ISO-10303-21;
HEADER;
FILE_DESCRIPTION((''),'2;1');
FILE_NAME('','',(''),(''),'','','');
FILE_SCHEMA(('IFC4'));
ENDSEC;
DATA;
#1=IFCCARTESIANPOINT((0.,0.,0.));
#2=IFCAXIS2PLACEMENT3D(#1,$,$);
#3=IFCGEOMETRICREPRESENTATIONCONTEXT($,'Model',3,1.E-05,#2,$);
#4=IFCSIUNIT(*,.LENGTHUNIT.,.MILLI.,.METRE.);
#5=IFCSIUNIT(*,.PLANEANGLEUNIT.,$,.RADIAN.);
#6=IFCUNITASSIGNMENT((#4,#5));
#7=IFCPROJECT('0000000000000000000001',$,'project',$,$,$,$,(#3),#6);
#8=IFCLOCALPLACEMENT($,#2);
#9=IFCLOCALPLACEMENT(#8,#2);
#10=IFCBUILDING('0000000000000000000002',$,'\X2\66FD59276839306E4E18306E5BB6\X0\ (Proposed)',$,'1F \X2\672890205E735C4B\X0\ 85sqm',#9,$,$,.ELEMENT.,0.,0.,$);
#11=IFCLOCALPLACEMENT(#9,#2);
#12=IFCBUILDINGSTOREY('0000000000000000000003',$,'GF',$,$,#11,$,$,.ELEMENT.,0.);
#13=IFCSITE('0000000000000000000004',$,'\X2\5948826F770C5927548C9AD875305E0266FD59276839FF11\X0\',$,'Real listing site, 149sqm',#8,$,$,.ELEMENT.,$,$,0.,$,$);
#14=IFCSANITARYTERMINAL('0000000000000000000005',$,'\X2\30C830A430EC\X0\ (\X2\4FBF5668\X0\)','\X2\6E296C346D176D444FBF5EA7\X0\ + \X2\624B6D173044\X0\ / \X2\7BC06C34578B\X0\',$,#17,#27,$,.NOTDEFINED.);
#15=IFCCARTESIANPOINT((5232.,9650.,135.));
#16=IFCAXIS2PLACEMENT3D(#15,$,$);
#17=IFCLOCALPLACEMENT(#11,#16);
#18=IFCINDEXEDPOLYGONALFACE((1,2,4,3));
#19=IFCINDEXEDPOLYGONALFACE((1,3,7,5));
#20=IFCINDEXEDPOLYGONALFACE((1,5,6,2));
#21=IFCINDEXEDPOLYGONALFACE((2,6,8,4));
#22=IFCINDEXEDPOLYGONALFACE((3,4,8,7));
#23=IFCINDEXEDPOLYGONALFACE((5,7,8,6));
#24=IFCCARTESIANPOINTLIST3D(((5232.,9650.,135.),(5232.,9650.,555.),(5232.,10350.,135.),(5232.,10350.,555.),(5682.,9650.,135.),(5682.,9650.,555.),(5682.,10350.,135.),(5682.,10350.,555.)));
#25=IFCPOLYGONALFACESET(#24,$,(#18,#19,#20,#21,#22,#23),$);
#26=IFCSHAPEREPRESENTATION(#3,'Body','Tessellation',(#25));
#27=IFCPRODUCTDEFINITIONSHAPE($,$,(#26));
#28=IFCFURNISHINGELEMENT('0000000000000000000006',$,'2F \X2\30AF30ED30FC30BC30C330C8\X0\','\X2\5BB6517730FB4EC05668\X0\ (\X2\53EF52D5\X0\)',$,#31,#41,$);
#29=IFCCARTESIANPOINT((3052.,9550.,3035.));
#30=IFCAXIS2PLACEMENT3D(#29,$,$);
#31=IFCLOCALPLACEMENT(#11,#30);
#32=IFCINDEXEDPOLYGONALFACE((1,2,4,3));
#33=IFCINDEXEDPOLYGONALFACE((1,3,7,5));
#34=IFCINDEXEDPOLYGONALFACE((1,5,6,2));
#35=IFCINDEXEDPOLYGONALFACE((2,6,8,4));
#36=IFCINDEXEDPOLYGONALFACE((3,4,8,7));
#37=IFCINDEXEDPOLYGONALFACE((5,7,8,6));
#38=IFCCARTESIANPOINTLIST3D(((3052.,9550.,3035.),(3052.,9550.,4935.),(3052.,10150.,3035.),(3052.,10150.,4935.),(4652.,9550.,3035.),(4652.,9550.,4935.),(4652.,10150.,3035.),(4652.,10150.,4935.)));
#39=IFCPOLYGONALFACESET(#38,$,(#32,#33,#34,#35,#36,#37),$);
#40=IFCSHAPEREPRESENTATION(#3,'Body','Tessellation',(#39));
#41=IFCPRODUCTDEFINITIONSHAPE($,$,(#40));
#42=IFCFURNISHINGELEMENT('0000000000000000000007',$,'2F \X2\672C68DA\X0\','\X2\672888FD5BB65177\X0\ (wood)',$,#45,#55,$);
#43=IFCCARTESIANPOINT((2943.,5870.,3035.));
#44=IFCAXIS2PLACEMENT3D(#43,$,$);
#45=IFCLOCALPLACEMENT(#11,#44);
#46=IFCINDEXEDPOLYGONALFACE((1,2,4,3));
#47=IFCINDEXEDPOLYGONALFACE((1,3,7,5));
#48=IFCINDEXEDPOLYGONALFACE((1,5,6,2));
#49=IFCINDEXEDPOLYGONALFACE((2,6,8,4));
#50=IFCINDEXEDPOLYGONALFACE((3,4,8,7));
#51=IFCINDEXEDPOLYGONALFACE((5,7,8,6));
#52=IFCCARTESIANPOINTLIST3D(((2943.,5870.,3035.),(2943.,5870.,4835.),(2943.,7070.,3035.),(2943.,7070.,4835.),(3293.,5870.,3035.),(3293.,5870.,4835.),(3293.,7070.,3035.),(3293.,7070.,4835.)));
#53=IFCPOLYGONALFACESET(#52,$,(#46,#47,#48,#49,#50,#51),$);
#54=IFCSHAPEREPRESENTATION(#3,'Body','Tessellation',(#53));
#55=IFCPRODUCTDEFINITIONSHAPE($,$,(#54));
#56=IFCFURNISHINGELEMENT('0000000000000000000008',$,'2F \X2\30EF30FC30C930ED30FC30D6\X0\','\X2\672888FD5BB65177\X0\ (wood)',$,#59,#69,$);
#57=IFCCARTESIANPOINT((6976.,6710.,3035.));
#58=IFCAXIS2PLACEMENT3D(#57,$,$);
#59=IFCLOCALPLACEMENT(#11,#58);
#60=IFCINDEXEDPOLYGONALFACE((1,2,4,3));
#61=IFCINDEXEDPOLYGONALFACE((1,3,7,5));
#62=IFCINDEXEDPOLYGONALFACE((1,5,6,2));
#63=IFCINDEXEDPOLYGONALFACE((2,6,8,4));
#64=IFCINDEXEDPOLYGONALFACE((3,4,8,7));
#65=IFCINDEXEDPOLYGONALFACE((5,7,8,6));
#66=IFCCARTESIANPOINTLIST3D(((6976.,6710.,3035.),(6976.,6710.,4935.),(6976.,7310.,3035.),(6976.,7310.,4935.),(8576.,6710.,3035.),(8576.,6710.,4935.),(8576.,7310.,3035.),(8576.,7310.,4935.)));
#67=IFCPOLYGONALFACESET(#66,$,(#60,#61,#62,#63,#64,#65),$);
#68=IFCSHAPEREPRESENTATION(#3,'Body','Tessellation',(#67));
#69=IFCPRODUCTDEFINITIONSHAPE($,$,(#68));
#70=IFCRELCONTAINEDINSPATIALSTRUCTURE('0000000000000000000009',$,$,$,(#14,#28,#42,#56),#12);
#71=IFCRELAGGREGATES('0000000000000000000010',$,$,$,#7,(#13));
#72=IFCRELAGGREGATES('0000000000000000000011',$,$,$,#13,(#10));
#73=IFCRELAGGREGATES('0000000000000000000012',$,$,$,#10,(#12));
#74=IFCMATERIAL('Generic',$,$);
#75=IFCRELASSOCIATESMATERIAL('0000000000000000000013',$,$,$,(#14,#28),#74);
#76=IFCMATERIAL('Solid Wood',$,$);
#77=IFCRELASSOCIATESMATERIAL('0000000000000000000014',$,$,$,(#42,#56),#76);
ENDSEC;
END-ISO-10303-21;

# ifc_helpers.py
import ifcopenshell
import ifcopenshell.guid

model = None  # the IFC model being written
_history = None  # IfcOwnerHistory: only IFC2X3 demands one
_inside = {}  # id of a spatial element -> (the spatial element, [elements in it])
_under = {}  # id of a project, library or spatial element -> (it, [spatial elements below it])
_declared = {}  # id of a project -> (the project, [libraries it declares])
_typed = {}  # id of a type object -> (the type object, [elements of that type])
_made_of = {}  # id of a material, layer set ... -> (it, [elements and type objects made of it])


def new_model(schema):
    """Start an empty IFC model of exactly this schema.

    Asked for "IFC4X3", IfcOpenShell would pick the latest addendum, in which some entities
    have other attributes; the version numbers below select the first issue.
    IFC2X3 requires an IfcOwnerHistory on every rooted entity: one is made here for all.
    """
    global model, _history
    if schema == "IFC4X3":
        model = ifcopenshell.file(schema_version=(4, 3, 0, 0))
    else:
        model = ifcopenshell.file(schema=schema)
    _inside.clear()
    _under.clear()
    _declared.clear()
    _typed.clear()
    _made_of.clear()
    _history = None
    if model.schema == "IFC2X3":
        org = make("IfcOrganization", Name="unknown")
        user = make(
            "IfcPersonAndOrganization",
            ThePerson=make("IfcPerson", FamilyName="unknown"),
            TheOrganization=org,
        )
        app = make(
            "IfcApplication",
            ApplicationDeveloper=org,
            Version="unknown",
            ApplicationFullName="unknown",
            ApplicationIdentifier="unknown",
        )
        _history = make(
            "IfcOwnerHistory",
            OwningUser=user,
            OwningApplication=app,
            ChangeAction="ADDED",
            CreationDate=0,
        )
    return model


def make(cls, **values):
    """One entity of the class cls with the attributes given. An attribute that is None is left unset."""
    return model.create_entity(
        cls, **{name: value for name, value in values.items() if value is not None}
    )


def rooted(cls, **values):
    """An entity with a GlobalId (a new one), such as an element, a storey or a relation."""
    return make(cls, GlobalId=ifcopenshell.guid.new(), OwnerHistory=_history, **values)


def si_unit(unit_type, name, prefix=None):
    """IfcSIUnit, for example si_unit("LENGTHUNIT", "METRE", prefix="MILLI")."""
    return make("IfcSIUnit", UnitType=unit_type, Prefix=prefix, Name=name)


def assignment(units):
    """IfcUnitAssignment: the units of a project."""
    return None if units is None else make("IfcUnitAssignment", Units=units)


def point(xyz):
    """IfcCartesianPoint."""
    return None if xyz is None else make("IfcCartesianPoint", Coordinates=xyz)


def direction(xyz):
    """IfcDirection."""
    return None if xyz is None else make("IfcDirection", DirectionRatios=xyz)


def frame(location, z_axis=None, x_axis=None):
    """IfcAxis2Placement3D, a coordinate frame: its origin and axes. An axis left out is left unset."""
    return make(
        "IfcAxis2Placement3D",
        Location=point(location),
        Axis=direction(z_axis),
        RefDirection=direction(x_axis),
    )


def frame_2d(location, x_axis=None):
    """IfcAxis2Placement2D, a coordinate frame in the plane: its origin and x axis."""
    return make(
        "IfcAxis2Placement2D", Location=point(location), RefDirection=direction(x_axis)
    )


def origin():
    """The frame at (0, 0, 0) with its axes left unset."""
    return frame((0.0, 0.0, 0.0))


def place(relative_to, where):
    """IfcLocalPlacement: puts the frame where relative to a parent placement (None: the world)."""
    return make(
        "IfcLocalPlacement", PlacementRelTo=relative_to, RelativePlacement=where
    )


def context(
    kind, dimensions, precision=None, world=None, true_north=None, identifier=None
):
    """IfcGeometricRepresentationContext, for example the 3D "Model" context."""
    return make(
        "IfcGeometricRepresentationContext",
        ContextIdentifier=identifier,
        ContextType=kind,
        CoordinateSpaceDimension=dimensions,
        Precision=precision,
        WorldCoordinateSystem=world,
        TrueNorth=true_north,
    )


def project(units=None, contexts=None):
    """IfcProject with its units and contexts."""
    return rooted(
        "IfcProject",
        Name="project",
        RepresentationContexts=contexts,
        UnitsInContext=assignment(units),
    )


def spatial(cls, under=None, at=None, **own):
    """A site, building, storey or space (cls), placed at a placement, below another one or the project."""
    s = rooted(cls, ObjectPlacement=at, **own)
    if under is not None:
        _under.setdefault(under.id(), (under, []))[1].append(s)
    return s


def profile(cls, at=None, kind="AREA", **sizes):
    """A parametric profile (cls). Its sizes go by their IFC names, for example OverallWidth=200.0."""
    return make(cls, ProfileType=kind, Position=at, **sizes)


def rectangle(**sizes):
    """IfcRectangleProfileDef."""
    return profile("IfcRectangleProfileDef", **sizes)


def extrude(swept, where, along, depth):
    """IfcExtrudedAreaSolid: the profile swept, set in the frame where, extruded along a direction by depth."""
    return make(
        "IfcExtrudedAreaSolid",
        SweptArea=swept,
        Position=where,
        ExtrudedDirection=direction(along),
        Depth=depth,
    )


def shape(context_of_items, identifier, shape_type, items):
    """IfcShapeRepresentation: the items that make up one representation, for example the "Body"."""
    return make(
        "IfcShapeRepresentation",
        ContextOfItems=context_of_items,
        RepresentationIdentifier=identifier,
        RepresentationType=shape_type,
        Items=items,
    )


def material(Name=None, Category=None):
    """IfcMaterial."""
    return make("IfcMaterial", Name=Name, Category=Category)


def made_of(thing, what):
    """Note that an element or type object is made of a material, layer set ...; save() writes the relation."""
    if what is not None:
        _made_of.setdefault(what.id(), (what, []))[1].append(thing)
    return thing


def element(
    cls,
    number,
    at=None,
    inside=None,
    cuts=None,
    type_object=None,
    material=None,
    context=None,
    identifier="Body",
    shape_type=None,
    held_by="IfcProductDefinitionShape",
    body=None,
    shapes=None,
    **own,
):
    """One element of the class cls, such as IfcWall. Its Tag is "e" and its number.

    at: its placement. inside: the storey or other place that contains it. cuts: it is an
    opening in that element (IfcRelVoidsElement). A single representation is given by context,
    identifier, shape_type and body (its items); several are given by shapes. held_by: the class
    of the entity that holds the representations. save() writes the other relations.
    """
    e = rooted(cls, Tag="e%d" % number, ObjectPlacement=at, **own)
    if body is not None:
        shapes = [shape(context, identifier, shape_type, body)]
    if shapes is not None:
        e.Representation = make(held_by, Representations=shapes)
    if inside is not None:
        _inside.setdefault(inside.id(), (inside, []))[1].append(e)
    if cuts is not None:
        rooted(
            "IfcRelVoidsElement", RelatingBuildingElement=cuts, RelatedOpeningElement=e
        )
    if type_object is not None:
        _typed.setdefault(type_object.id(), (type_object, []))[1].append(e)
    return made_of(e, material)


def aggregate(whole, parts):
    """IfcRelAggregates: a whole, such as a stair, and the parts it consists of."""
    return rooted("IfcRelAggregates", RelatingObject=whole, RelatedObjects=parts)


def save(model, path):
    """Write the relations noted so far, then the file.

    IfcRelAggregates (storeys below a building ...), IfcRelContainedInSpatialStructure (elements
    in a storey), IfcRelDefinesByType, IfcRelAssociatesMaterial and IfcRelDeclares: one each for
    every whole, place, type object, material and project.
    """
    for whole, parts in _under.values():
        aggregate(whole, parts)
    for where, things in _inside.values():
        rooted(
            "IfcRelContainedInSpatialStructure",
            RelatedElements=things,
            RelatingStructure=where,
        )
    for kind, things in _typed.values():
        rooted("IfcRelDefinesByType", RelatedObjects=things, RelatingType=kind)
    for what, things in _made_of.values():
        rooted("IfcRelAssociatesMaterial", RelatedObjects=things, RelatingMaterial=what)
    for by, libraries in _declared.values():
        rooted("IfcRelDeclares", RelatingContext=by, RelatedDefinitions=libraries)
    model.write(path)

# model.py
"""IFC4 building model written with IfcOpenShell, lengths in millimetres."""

from ifc_helpers import new_model, si_unit, frame, frame_2d, origin, place, context, project, spatial, rectangle, extrude, material, element, save


model = new_model("IFC4")

# Units and contexts
model_context = context("Model", 3, precision=1e-05, world=origin())
ifc_project = project(units=[si_unit("LENGTHUNIT", "METRE", prefix="MILLI"), si_unit("PLANEANGLEUNIT", "RADIAN")], contexts=[model_context])

# Site, building, storey
site_placement = place(None, origin())
site = spatial("IfcSite", under=ifc_project, at=site_placement, Name="奈良県大和高田市曽大根１", ObjectType="Real listing site, 149sqm", CompositionType="ELEMENT", RefElevation=0.0)
building_placement = place(site_placement, origin())
building = spatial("IfcBuilding", under=site, at=building_placement, Name="曽大根の丘の家 (Proposed)", ObjectType="1F 木造平屋 85sqm", CompositionType="ELEMENT", ElevationOfRefHeight=0.0, ElevationOfTerrain=0.0)
storey_placement = place(building_placement, origin())
storey = spatial("IfcBuildingStorey", under=building, at=storey_placement, Name="GF", CompositionType="ELEMENT", Elevation=0.0)

# Shared definitions
ifc_material_1 = material(Name="Solid Wood")

# Shared definitions
ifc_material_2 = material(Name="Generic")

# Sanitary terminal
sanitary_terminal_placement = place(storey_placement, frame((5232.0, 9650.0, 135.0)))
element("IfcSanitaryTerminal", 1, at=sanitary_terminal_placement, inside=storey, material=ifc_material_2, Name="トイレ (便器)", Description="温水洗浄便座 + 手洗い / 節水型", PredefinedType="NOTDEFINED", context=model_context, shape_type="SweptSolid", body=[
    extrude(rectangle(XDim=450.0, YDim=700.0, at=frame_2d((225.0, 350.0))), frame((5232.0, 9650.0, 135.0)), (0.0, 0.0, 1.0), 420.0),
])

# Furnishing elements
furnishing_1_placement = place(storey_placement, frame((3052.0, 9550.0, 3035.0)))
element("IfcFurnishingElement", 2, at=furnishing_1_placement, inside=storey, material=ifc_material_2, Name="2F クローゼット", Description="家具・什器 (可動)", context=model_context, shape_type="SweptSolid", body=[
    extrude(rectangle(XDim=1600.0, YDim=600.0, at=frame_2d((800.0, 300.0))), frame((3052.0, 9550.0, 3035.0)), (0.0, 0.0, 1.0), 1900.0),
])
furnishing_2_placement = place(storey_placement, frame((2943.0, 5870.0, 3035.0)))
element("IfcFurnishingElement", 3, at=furnishing_2_placement, inside=storey, material=ifc_material_1, Name="2F 本棚", Description="木製家具 (wood)", context=model_context, shape_type="SweptSolid", body=[
    extrude(rectangle(XDim=350.0, YDim=1200.0, at=frame_2d((175.0, 600.0))), frame((2943.0, 5870.0, 3035.0)), (0.0, 0.0, 1.0), 1800.0),
])
furnishing_3_placement = place(storey_placement, frame((6976.0, 6710.0, 3035.0)))
element("IfcFurnishingElement", 4, at=furnishing_3_placement, inside=storey, material=ifc_material_1, Name="2F ワードローブ", Description="木製家具 (wood)", context=model_context, shape_type="SweptSolid", body=[
    extrude(rectangle(XDim=1600.0, YDim=600.0, at=frame_2d((800.0, 300.0))), frame((6976.0, 6710.0, 3035.0)), (0.0, 0.0, 1.0), 1900.0),
])

save(model, "model.ifc")
